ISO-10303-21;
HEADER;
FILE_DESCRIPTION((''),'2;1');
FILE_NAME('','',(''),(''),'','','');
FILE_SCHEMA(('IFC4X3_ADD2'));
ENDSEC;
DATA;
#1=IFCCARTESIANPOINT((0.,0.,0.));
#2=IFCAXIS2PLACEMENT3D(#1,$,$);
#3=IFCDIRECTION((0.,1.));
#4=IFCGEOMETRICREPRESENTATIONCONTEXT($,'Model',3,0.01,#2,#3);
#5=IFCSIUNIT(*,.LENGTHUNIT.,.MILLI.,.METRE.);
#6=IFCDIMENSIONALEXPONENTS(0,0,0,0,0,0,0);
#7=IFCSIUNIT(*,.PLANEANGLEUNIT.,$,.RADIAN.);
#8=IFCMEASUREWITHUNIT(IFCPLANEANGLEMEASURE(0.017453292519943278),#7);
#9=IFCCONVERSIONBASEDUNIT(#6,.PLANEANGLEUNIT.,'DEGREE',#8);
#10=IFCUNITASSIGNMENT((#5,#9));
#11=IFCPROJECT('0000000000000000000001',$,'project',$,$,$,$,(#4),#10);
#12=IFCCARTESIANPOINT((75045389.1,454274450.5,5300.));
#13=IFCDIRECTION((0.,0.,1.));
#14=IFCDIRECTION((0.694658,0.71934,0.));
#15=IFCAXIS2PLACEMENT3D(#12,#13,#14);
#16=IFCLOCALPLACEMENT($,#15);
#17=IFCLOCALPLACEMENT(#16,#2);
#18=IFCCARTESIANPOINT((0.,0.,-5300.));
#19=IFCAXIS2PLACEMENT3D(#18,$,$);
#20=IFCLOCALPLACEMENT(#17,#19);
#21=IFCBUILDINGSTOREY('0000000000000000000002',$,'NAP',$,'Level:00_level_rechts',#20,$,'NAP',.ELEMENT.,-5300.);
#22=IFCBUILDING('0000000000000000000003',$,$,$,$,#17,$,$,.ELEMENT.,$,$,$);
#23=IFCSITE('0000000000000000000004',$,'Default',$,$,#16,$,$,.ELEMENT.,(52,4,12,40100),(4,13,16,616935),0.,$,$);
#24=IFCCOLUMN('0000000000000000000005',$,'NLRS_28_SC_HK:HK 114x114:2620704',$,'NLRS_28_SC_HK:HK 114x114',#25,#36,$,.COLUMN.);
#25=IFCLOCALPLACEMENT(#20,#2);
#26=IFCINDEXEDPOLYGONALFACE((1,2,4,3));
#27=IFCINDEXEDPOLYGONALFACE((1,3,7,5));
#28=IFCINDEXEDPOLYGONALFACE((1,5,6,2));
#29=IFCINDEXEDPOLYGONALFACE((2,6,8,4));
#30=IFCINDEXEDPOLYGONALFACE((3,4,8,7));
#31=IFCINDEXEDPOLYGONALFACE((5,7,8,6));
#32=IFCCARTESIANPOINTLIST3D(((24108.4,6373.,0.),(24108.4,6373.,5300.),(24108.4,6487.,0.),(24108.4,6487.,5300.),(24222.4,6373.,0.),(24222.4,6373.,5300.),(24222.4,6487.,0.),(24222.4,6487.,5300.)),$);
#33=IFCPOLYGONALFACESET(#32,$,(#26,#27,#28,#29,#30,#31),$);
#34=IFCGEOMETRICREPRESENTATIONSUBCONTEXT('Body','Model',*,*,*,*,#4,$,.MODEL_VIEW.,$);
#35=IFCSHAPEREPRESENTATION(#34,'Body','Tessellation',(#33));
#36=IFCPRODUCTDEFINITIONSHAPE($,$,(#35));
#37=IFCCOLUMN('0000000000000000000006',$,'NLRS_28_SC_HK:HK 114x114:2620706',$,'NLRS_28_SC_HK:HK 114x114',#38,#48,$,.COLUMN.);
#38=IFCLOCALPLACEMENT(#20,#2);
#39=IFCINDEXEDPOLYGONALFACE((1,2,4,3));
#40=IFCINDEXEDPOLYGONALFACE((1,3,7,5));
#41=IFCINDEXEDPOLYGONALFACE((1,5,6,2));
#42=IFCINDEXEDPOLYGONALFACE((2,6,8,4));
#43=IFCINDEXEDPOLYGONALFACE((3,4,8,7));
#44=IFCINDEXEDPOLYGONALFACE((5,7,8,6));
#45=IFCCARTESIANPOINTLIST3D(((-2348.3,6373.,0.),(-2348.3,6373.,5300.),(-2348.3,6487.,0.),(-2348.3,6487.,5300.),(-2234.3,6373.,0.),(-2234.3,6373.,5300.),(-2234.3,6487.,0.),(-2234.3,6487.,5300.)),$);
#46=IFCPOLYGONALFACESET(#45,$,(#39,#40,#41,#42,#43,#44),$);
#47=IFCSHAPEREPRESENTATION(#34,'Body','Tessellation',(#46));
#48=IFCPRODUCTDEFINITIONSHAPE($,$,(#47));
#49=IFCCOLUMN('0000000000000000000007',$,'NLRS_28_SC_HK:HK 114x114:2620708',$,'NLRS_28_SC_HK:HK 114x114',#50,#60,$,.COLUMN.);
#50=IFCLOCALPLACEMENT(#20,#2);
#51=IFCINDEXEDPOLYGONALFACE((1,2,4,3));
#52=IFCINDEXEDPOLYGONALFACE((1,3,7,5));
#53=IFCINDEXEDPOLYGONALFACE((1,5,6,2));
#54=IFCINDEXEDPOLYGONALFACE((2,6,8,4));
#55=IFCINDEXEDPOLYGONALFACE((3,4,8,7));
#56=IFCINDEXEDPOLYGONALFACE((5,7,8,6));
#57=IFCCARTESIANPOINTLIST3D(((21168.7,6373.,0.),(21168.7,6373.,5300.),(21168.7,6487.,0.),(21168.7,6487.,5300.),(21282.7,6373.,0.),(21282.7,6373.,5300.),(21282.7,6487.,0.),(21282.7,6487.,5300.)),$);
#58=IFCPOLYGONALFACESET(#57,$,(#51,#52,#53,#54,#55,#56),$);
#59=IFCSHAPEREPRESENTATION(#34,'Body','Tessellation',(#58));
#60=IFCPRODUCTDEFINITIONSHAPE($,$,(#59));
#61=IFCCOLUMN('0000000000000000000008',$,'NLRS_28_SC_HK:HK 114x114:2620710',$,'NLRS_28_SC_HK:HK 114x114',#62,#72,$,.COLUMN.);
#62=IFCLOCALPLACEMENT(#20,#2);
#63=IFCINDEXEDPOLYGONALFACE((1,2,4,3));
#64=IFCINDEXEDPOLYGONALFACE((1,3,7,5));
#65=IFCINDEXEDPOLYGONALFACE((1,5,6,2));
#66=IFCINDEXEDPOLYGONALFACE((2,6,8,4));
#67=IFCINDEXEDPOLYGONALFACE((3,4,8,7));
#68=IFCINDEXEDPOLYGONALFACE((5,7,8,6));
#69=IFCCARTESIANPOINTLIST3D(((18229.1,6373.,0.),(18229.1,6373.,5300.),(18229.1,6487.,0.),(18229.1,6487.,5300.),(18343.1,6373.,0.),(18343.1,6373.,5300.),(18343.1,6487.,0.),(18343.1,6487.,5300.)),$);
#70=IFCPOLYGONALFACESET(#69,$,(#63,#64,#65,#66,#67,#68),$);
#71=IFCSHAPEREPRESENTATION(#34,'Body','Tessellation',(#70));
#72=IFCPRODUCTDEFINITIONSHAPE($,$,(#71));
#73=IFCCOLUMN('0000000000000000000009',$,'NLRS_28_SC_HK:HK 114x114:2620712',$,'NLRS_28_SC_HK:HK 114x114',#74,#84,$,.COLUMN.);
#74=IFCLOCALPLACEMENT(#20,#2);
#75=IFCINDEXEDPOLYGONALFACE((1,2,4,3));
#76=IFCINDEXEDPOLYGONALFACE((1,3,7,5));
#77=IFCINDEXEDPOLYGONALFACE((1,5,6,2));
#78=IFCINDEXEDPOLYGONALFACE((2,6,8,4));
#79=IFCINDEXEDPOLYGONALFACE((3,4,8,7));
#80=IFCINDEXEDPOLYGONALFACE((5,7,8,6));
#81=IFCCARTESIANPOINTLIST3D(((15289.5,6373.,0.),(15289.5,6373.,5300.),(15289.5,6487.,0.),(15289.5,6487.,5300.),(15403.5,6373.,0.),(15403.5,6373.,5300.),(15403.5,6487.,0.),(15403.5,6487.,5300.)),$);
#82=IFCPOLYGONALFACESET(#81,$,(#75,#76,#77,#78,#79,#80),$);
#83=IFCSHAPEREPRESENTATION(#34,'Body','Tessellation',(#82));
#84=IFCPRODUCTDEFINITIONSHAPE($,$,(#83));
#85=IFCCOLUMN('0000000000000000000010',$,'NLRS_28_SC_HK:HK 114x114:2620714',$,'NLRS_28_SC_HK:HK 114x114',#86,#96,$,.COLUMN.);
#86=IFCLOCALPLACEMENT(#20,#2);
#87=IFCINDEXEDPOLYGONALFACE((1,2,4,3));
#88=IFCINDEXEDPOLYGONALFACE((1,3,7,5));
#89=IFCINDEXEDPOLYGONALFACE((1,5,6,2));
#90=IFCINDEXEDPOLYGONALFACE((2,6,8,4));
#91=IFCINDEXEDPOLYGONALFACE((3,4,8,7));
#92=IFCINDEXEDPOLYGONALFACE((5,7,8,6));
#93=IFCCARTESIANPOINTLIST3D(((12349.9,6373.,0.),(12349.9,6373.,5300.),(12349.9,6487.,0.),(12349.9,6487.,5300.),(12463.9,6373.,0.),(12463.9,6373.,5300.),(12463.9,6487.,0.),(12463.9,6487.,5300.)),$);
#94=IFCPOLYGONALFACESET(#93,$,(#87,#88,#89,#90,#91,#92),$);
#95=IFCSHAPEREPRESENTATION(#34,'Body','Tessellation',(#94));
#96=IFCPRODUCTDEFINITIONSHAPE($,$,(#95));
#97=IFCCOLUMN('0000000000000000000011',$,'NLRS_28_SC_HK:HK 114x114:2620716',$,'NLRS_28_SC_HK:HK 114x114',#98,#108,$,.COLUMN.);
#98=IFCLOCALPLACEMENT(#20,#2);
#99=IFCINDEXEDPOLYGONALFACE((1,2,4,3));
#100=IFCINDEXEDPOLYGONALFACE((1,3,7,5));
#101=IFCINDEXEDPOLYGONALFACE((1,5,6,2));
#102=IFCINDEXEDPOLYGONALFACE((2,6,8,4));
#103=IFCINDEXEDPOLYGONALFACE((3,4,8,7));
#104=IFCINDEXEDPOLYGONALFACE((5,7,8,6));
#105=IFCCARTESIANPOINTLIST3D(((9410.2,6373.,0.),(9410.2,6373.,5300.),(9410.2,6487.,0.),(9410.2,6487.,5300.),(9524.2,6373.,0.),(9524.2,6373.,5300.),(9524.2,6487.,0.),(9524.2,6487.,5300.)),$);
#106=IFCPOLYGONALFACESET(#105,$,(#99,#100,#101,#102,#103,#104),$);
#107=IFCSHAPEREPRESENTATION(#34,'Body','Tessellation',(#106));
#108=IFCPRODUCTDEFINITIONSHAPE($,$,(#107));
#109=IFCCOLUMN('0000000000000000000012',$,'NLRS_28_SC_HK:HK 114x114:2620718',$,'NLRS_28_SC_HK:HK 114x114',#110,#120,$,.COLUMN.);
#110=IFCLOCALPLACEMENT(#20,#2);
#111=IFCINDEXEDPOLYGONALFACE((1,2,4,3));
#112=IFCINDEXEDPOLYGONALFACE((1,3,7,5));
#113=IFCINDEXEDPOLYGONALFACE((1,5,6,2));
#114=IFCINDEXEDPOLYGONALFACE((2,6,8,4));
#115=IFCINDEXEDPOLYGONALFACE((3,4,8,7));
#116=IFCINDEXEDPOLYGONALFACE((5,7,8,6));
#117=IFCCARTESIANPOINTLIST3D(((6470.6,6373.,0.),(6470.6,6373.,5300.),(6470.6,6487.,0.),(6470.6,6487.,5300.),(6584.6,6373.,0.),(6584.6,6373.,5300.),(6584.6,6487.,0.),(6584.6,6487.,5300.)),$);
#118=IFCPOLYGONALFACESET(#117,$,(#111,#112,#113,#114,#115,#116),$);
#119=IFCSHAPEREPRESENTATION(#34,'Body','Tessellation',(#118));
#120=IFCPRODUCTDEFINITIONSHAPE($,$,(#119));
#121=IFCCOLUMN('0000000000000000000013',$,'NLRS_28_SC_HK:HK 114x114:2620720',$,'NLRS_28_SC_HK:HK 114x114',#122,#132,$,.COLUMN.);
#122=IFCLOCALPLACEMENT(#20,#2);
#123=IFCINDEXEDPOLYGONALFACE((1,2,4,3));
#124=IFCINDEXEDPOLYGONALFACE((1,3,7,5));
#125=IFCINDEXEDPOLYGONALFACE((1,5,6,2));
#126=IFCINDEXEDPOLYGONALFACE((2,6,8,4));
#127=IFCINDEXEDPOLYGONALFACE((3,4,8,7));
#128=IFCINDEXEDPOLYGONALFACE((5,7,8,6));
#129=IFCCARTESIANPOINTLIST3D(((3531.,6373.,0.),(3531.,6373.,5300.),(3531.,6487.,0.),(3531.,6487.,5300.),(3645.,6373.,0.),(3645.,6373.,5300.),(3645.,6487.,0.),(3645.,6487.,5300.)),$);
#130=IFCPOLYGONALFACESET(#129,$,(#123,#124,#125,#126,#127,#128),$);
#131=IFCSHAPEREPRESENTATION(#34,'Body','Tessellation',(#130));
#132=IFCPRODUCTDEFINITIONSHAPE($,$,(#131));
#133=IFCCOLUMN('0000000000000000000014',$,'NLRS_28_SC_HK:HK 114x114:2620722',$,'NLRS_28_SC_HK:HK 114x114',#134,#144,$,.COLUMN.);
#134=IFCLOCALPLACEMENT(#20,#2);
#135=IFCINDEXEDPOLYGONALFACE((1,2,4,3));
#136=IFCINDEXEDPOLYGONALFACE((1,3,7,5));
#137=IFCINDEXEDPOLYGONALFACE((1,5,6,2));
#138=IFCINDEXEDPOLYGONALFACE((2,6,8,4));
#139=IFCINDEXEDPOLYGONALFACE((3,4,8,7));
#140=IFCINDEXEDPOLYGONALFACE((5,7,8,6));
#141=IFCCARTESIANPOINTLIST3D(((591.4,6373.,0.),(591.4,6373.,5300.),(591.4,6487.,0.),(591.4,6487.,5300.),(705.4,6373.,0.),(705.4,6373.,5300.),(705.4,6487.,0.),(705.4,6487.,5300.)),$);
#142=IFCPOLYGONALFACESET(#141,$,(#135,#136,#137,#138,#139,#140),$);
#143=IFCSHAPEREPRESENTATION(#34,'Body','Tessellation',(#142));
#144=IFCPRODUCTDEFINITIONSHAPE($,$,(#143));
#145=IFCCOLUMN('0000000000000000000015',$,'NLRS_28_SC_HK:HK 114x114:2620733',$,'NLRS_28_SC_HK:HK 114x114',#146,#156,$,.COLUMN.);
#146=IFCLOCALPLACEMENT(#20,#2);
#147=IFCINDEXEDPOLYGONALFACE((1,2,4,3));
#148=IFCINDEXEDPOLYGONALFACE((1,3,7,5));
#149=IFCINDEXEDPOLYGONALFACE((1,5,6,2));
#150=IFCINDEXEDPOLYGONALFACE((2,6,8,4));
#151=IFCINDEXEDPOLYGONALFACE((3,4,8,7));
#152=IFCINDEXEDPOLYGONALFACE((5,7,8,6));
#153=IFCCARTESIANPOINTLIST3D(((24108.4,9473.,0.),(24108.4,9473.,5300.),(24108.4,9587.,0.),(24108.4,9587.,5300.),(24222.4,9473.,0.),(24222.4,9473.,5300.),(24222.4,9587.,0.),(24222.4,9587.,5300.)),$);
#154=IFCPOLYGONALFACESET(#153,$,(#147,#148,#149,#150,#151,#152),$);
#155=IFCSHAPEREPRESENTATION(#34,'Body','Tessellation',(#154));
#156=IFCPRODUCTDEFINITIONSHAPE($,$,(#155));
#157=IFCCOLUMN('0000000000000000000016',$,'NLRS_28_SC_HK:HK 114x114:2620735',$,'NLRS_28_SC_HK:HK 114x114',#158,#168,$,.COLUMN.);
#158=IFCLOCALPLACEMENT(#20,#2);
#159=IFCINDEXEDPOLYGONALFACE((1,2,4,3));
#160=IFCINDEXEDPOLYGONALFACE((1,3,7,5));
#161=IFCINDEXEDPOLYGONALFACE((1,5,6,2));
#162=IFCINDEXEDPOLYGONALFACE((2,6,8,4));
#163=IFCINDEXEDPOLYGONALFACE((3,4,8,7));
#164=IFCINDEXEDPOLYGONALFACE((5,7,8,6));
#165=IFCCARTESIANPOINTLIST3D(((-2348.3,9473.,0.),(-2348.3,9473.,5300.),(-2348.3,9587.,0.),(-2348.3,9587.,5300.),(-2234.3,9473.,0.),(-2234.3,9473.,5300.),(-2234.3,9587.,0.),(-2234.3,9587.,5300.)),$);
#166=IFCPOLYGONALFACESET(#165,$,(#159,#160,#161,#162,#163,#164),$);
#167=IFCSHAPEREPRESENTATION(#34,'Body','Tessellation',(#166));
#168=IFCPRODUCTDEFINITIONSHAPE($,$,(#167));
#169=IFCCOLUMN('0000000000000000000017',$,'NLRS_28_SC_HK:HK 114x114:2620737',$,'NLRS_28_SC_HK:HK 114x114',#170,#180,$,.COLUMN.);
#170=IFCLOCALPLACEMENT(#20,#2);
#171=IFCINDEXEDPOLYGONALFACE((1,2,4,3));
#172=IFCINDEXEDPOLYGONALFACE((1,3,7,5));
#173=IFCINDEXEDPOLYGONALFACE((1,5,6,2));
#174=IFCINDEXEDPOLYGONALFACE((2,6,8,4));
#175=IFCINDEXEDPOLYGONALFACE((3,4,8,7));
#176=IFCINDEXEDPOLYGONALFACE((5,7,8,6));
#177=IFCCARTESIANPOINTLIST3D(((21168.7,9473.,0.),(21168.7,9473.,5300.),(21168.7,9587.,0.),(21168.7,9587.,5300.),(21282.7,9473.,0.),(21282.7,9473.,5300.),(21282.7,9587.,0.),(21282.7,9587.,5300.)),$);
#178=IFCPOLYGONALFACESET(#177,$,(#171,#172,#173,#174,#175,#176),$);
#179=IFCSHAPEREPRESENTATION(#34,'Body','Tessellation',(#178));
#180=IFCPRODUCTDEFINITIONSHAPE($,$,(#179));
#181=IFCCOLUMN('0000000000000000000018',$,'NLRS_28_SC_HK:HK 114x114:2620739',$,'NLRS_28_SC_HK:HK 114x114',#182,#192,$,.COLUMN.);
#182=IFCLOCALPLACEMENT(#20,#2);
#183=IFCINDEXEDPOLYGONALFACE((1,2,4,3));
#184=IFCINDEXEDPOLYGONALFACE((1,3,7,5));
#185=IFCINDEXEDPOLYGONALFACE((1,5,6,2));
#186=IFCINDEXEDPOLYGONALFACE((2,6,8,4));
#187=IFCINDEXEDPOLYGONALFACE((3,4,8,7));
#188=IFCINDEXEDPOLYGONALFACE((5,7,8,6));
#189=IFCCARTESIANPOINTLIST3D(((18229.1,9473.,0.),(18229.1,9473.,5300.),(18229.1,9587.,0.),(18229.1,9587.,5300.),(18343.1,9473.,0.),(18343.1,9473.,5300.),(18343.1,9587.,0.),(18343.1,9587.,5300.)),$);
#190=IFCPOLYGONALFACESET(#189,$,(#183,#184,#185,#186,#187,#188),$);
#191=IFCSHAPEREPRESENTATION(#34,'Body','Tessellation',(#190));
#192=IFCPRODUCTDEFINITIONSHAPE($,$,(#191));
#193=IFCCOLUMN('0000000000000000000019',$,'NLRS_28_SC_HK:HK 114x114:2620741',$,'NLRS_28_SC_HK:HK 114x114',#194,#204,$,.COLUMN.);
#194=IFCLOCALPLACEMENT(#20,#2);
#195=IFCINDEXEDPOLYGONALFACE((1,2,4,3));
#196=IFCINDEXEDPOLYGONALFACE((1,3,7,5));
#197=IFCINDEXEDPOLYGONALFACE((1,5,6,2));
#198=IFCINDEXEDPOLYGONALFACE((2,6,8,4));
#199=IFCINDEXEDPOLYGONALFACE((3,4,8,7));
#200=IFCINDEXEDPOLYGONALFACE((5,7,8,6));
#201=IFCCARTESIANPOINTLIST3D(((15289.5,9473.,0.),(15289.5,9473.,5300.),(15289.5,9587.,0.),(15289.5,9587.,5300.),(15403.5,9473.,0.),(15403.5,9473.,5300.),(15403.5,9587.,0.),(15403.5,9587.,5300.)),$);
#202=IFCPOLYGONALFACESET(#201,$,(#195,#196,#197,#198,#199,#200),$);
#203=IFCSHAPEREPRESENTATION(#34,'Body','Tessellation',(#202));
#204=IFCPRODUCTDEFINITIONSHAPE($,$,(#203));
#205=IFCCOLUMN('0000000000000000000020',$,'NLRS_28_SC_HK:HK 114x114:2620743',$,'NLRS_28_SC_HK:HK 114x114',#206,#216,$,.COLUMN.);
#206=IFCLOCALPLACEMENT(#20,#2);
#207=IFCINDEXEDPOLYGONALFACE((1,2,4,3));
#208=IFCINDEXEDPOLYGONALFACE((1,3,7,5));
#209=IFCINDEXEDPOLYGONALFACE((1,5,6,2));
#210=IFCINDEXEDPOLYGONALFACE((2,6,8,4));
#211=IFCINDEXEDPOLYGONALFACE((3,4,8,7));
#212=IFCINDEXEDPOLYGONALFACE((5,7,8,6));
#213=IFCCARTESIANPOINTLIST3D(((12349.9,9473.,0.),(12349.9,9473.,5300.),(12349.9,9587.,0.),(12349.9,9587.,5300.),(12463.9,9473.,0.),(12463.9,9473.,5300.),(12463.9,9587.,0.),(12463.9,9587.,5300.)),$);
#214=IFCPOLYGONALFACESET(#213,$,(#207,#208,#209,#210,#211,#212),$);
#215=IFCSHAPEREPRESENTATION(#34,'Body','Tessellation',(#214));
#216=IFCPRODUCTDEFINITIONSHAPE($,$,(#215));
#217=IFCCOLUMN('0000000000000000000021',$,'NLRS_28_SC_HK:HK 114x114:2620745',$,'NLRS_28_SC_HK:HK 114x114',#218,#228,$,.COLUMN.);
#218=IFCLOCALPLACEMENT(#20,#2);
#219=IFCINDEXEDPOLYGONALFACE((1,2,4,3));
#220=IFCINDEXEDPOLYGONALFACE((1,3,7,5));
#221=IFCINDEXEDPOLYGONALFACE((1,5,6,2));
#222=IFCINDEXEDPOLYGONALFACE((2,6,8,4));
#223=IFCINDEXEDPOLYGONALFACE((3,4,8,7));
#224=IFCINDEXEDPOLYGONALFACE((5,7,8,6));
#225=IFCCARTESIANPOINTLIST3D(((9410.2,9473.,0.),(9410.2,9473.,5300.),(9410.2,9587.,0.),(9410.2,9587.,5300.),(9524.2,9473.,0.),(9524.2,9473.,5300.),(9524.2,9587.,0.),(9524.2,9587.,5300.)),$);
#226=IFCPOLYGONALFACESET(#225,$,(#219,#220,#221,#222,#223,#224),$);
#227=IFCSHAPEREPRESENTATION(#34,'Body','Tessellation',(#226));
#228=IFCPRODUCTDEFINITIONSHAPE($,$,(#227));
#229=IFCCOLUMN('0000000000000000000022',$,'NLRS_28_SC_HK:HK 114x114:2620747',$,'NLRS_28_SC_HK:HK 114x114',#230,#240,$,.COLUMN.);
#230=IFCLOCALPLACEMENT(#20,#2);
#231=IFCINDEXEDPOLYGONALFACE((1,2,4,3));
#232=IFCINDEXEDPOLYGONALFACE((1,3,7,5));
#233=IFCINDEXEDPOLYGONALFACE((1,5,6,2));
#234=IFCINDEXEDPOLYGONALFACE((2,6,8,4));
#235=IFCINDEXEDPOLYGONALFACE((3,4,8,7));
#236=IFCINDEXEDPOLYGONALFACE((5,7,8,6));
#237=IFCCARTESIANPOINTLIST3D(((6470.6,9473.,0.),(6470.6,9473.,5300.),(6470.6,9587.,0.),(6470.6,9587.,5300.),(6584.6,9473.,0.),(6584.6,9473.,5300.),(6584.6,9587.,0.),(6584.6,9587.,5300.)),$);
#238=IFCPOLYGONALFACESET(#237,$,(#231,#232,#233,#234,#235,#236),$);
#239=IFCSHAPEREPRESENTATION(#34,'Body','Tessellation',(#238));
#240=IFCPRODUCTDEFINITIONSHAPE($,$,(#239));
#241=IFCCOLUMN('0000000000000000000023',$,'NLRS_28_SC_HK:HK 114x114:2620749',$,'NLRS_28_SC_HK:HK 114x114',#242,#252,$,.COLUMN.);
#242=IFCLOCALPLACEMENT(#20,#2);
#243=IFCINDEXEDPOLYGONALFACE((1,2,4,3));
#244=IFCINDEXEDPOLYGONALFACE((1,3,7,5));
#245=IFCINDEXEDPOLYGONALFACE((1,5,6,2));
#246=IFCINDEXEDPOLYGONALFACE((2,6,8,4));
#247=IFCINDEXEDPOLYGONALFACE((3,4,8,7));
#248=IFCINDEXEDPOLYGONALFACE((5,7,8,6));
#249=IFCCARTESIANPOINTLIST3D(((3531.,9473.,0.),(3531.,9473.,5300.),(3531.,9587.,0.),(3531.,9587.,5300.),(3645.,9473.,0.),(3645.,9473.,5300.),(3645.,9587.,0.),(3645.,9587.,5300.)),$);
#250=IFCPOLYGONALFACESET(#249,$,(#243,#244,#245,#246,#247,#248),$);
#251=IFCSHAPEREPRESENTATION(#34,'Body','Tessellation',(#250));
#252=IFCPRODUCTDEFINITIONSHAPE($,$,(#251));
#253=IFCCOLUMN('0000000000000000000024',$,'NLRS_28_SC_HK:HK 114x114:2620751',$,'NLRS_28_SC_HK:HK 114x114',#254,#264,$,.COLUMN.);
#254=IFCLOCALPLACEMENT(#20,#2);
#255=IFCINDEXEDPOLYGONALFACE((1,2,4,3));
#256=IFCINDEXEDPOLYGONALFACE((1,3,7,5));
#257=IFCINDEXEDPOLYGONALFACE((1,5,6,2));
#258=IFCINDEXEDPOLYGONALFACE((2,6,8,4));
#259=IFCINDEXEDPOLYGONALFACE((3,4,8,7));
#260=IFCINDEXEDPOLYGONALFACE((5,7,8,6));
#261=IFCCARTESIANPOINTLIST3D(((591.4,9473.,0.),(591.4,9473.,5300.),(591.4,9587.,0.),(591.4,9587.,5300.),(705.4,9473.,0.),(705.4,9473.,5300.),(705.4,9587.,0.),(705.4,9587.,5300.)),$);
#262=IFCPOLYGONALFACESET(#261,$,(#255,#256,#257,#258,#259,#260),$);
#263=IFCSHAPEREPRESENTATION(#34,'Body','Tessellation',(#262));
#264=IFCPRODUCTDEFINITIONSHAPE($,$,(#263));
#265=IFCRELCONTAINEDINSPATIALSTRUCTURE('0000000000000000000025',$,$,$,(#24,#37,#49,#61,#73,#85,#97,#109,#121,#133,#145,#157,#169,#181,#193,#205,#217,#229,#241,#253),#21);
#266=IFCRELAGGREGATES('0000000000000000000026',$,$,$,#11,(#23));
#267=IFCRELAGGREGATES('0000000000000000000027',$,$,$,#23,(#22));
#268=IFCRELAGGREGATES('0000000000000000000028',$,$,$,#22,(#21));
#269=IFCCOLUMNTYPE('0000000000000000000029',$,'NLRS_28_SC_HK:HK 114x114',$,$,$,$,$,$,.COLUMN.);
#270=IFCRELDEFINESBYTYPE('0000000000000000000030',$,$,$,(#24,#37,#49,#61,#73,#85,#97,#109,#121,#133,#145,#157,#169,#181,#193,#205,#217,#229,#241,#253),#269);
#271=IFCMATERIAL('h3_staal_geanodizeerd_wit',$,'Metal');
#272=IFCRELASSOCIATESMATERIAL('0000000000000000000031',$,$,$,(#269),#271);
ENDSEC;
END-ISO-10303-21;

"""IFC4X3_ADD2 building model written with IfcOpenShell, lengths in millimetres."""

from ifc_helpers import new_model, entity, si_unit, converted_unit, direction, frame, origin, origin_2d_with_axis, place, context, subcontext, project, spatial, rectangle, extrude, source, transform, mapped, material, material_profile, profile_set, type_object, type_shapes, element, save


model = new_model("IFC4X3_ADD2")

# Units and contexts
model_context = context("Model", 3, precision=0.01, world=origin(), true_north=direction((0.0, 1.0)))
body_context = subcontext(model_context, "Body", "Model", "MODEL_VIEW")
ifc_project = project(units=[si_unit("LENGTHUNIT", "METRE", prefix="MILLI"), converted_unit("PLANEANGLEUNIT", "DEGREE", entity("IfcPlaneAngleMeasure", 0.017453292519943278), si_unit("PLANEANGLEUNIT", "RADIAN"), dimensions=[0, 0, 0, 0, 0, 0, 0])], contexts=[model_context])

# Site, building, storey
site_placement = place(None, frame((75045389.1, 454274450.5, 5300.0), z_axis=(0.0, 0.0, 1.0), x_axis=(0.694658, 0.71934, 0.0)))
site = spatial("IfcSite", under=ifc_project, at=site_placement, Name="Default", CompositionType="ELEMENT", RefLatitude=(52, 4, 12, 40100), RefLongitude=(4, 13, 16, 616935), RefElevation=0.0)
building_placement = place(site_placement, origin())
building = spatial("IfcBuilding", under=site, at=building_placement, CompositionType="ELEMENT")
storey_placement = place(building_placement, frame((0.0, 0.0, -5300.0)))
storey = spatial("IfcBuildingStorey", under=building, at=storey_placement, Name="NAP", ObjectType="Level:00_level_rechts", LongName="NAP", CompositionType="ELEMENT", Elevation=-5300.0)

# Columns
ifc_material = material(Name="h3_staal_geanodizeerd_wit", Category="Metal")
ifc_material_profile = material_profile(ifc_material, rectangle(XDim=114.0, YDim=114.0, at=origin_2d_with_axis()), Name="HK 114x114")
ifc_profile_set = profile_set([ifc_material_profile], Name="HK 114x114")
column_type = type_object("IfcColumnType", Name="NLRS_28_SC_HK:HK 114x114", PredefinedType="COLUMN", material=ifc_profile_set)
shared_shape = source(origin(), body_context, "Body", "SweptSolid", [
    extrude(rectangle(XDim=114.0, YDim=114.0, at=origin_2d_with_axis()), frame((0.0, 0.0, -5300.0), z_axis=(0.0, 0.0, 1.0), x_axis=(-1.0, 0.0, 0.0)), (0.0, 0.0, 1.0), 5300.0),
])
type_shapes(column_type, [shared_shape])
for number, where, name in (
    (1, (24165.4, 6430.0, 5300.0), "NLRS_28_SC_HK:HK 114x114:2620704"),
    (2, (-2291.3, 6430.0, 5300.0), "NLRS_28_SC_HK:HK 114x114:2620706"),
    (3, (21225.7, 6430.0, 5300.0), "NLRS_28_SC_HK:HK 114x114:2620708"),
    (4, (18286.1, 6430.0, 5300.0), "NLRS_28_SC_HK:HK 114x114:2620710"),
    (5, (15346.5, 6430.0, 5300.0), "NLRS_28_SC_HK:HK 114x114:2620712"),
    (6, (12406.9, 6430.0, 5300.0), "NLRS_28_SC_HK:HK 114x114:2620714"),
    (7, (9467.2, 6430.0, 5300.0), "NLRS_28_SC_HK:HK 114x114:2620716"),
    (8, (6527.6, 6430.0, 5300.0), "NLRS_28_SC_HK:HK 114x114:2620718"),
    (9, (3588.0, 6430.0, 5300.0), "NLRS_28_SC_HK:HK 114x114:2620720"),
    (10, (648.4, 6430.0, 5300.0), "NLRS_28_SC_HK:HK 114x114:2620722"),
    (11, (24165.4, 9530.0, 5300.0), "NLRS_28_SC_HK:HK 114x114:2620733"),
    (12, (-2291.3, 9530.0, 5300.0), "NLRS_28_SC_HK:HK 114x114:2620735"),
    (13, (21225.7, 9530.0, 5300.0), "NLRS_28_SC_HK:HK 114x114:2620737"),
    (14, (18286.1, 9530.0, 5300.0), "NLRS_28_SC_HK:HK 114x114:2620739"),
    (15, (15346.5, 9530.0, 5300.0), "NLRS_28_SC_HK:HK 114x114:2620741"),
    (16, (12406.9, 9530.0, 5300.0), "NLRS_28_SC_HK:HK 114x114:2620743"),
    (17, (9467.2, 9530.0, 5300.0), "NLRS_28_SC_HK:HK 114x114:2620745"),
    (18, (6527.6, 9530.0, 5300.0), "NLRS_28_SC_HK:HK 114x114:2620747"),
    (19, (3588.0, 9530.0, 5300.0), "NLRS_28_SC_HK:HK 114x114:2620749"),
    (20, (648.4, 9530.0, 5300.0), "NLRS_28_SC_HK:HK 114x114:2620751"),
):
    element("IfcColumn", number, at=place(storey_placement, frame(where)), inside=storey, type_object=column_type, Name=name, ObjectType="NLRS_28_SC_HK:HK 114x114", PredefinedType="COLUMN", context=body_context, shape_type="MappedRepresentation", body=[
        mapped(shared_shape, transform((0.0, 0.0, 0.0), scale=1.0)),
    ])

save(model, "model.ifc")
